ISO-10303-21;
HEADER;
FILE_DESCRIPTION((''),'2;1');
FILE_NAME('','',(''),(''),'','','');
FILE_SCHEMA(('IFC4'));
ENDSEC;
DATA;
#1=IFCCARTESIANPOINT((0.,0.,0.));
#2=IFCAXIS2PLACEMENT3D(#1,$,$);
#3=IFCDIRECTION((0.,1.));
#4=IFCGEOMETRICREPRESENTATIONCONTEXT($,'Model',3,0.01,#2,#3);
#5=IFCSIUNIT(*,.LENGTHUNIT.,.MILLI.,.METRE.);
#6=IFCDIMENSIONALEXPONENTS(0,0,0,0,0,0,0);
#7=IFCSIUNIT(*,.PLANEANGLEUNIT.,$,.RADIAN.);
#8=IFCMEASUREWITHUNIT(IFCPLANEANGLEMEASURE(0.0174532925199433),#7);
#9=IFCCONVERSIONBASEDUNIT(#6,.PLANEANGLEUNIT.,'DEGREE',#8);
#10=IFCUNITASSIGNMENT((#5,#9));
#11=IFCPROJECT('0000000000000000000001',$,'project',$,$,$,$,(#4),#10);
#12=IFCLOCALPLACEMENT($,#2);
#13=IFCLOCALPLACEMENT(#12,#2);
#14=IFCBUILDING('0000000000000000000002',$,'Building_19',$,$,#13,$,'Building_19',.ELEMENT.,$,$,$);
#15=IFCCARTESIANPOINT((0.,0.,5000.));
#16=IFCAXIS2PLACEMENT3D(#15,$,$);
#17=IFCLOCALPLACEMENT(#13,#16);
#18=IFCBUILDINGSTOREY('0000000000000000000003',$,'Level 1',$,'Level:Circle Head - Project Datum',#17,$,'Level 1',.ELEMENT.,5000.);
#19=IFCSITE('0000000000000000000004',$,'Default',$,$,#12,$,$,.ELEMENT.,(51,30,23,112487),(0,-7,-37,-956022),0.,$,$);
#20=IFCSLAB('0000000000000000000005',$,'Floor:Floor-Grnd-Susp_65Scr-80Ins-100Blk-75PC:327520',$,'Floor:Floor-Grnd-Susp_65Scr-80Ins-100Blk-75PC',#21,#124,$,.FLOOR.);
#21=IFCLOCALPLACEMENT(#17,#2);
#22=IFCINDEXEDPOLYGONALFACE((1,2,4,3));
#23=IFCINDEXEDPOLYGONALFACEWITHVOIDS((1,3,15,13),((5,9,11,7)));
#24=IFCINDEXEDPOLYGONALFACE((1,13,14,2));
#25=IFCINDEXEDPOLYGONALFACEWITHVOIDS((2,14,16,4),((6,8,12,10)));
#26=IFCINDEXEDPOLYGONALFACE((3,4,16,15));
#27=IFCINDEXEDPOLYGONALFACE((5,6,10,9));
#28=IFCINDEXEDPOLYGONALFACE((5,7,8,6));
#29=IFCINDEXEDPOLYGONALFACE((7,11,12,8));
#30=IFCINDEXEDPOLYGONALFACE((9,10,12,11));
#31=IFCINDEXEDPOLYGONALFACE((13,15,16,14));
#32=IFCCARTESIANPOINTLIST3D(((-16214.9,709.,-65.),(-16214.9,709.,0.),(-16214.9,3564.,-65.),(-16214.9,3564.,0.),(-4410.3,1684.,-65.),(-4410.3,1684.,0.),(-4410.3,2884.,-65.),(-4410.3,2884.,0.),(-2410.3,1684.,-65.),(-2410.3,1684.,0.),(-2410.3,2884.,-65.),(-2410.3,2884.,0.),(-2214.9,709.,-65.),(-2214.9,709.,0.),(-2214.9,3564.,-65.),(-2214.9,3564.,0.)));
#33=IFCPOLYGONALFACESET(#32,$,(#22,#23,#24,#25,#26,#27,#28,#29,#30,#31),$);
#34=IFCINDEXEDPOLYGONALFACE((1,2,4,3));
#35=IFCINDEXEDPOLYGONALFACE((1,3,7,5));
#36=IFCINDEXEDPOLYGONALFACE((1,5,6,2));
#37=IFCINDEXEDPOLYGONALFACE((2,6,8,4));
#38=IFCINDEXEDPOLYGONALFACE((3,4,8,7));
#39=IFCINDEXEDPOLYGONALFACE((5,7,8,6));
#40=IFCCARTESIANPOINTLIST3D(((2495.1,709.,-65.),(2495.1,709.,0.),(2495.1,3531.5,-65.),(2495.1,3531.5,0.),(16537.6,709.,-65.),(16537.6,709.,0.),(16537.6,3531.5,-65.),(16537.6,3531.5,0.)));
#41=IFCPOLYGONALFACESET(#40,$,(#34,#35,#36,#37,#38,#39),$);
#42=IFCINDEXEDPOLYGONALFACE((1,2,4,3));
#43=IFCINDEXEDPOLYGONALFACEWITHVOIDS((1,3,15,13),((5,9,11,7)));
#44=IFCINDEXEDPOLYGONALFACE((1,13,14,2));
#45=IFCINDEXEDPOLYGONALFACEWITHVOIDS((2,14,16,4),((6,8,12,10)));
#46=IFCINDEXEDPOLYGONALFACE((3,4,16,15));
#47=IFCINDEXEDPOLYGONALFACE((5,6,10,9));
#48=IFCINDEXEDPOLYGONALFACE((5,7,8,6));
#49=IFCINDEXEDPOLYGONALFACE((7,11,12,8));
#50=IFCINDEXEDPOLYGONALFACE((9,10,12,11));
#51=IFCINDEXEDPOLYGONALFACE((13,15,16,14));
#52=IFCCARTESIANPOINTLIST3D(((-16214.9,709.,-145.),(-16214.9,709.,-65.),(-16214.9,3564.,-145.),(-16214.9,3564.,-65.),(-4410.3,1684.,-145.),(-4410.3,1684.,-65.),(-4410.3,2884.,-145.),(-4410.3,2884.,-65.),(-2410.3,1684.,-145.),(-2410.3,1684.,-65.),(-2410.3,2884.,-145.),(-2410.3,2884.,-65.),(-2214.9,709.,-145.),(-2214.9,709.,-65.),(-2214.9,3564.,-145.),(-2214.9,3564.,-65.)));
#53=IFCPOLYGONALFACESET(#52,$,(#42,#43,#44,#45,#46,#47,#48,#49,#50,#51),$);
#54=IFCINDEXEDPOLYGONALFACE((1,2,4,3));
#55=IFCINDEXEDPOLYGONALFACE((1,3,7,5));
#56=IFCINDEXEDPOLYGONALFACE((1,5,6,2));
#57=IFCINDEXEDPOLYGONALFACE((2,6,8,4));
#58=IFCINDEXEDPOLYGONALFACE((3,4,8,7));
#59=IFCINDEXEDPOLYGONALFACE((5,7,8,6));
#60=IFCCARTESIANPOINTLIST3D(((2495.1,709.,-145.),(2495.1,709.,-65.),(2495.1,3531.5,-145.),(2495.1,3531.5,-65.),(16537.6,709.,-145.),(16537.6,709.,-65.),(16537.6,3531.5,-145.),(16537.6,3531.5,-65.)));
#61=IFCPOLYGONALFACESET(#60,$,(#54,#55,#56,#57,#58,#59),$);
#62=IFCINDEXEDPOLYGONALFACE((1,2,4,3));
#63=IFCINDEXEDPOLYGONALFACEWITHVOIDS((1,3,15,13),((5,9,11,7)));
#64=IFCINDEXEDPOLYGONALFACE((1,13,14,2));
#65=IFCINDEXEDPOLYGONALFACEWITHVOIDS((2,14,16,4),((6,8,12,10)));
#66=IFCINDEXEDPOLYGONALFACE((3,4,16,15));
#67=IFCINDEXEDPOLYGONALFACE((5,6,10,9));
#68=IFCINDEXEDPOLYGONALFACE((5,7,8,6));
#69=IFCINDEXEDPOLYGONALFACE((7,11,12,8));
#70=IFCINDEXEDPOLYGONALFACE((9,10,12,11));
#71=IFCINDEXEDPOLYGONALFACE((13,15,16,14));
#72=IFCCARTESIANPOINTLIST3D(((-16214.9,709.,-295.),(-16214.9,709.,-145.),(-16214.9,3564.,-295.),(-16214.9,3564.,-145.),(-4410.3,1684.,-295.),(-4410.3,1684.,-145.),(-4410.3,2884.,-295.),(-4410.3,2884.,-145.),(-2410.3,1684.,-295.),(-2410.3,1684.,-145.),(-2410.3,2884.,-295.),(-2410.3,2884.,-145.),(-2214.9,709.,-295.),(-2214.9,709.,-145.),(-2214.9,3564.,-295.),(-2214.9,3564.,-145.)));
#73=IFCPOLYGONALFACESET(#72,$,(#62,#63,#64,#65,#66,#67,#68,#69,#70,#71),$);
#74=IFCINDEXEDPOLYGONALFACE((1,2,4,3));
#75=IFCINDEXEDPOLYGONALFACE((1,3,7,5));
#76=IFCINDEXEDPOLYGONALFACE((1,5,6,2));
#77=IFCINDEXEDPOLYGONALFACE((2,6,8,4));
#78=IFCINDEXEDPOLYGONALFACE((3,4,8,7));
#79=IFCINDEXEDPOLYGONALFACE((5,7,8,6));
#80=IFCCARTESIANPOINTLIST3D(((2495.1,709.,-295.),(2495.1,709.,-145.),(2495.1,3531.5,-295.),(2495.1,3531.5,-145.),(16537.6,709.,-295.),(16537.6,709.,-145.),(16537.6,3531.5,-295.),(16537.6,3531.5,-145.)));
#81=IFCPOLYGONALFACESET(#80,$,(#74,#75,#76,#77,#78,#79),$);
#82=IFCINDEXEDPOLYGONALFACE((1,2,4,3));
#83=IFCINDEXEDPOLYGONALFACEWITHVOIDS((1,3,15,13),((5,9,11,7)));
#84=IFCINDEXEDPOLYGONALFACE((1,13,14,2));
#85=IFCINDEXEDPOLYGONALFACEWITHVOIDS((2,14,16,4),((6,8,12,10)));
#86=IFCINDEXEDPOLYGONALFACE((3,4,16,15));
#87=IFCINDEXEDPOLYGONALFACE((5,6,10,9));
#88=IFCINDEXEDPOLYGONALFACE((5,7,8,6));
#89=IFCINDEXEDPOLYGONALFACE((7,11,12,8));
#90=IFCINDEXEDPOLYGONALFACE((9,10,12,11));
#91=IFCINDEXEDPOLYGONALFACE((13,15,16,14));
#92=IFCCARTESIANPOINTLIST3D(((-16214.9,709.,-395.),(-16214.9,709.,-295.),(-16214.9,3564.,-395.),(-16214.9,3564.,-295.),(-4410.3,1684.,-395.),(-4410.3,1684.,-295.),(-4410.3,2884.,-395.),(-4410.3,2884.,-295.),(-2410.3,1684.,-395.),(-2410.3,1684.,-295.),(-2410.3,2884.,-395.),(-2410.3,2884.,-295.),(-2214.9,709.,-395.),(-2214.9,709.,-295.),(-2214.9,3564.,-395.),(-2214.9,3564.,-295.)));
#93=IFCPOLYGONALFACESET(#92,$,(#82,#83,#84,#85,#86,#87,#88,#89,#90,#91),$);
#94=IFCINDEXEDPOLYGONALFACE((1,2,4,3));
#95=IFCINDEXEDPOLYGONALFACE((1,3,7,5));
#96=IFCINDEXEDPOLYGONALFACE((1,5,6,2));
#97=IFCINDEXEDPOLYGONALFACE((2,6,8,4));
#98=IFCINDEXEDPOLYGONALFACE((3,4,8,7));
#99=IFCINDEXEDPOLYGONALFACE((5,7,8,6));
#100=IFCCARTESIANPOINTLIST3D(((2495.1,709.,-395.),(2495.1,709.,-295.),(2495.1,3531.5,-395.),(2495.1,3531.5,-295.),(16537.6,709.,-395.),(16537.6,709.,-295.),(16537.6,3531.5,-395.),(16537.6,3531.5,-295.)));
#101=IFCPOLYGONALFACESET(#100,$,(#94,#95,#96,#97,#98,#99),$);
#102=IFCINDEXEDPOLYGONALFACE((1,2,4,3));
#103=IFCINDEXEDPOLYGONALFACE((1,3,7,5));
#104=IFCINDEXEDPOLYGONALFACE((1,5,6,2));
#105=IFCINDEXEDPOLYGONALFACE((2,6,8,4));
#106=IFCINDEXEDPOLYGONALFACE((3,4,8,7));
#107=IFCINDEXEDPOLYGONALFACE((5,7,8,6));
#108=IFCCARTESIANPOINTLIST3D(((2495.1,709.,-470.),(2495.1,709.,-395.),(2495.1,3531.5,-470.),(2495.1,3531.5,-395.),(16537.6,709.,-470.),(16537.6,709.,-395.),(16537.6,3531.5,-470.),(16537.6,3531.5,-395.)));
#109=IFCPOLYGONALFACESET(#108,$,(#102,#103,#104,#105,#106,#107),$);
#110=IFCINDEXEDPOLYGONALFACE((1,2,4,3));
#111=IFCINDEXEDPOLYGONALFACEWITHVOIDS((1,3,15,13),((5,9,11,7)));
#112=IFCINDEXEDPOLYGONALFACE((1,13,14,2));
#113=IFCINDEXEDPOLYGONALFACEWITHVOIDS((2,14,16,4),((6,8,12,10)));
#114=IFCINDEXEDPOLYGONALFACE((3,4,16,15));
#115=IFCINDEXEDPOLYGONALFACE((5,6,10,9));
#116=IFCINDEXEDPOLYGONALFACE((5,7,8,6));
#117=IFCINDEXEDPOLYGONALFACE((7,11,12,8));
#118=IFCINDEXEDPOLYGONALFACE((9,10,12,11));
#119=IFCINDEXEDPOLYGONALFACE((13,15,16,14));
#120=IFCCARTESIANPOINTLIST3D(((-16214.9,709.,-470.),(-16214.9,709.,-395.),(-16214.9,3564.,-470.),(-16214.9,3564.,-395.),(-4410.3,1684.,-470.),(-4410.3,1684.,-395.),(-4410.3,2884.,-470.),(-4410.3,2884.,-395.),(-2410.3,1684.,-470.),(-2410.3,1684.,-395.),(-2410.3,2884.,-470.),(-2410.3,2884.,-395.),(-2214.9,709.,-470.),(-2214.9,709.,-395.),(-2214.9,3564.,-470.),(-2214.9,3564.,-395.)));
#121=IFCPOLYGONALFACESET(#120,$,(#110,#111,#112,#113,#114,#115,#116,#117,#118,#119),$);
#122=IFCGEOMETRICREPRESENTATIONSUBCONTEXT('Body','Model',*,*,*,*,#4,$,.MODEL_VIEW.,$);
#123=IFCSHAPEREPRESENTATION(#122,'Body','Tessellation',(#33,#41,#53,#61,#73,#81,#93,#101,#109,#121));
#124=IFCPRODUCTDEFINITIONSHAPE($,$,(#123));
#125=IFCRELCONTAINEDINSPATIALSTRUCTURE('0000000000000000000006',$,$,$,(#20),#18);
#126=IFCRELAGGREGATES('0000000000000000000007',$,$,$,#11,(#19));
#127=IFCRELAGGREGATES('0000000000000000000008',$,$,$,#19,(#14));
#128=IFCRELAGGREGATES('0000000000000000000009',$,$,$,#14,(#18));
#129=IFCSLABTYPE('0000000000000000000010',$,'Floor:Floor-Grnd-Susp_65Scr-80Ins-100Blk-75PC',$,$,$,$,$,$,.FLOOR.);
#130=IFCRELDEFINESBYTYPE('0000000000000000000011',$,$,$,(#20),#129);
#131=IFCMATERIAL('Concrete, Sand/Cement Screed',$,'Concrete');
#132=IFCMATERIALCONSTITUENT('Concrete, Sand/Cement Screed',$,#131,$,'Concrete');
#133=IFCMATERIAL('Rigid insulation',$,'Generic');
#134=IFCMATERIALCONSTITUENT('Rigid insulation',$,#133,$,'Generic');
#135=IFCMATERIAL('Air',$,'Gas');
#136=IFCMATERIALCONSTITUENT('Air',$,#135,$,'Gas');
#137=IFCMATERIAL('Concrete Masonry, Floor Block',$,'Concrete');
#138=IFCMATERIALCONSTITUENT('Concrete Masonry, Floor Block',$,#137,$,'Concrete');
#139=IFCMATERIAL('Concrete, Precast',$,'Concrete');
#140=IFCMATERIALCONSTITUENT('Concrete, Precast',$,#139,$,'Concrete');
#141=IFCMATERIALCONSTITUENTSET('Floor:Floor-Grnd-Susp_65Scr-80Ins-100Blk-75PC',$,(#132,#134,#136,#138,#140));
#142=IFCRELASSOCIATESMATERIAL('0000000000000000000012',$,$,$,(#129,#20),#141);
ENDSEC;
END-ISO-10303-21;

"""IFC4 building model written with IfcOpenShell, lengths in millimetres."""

from ifc_helpers import new_model, entity, si_unit, converted_unit, direction, frame, origin, place, context, subcontext, project, spatial, indexed_curve, outline, extrude, material, constituent, constituent_set, type_object, element, save


model = new_model("IFC4")

# Units and contexts
model_context = context("Model", 3, precision=0.01, world=origin(), true_north=direction((0.0, 1.0)))
body_context = subcontext(model_context, "Body", "Model", "MODEL_VIEW")
ifc_project = project(units=[si_unit("LENGTHUNIT", "METRE", prefix="MILLI"), converted_unit("PLANEANGLEUNIT", "DEGREE", entity("IfcPlaneAngleMeasure", 0.0174532925199433), si_unit("PLANEANGLEUNIT", "RADIAN"), dimensions=[0, 0, 0, 0, 0, 0, 0])], contexts=[model_context])

# Site, building, storey
site_placement = place(None, origin())
site = spatial("IfcSite", under=ifc_project, at=site_placement, Name="Default", CompositionType="ELEMENT", RefLatitude=(51, 30, 23, 112487), RefLongitude=(0, -7, -37, -956022), RefElevation=0.0)
building_placement = place(site_placement, origin())
building = spatial("IfcBuilding", under=site, at=building_placement, Name="Building_19", LongName="Building_19", CompositionType="ELEMENT")
storey_placement = place(building_placement, frame((0.0, 0.0, 5000.0)))
storey = spatial("IfcBuildingStorey", under=building, at=storey_placement, Name="Level 1", ObjectType="Level:Circle Head - Project Datum", LongName="Level 1", CompositionType="ELEMENT", Elevation=5000.0)

# Slab, opening
ifc_material_1 = material(Name="Concrete, Sand/Cement Screed", Category="Concrete")
ifc_constituent_1 = constituent(ifc_material_1, Name="Concrete, Sand/Cement Screed", Category="Concrete")
ifc_material_2 = material(Name="Rigid insulation", Category="Generic")
ifc_constituent_2 = constituent(ifc_material_2, Name="Rigid insulation", Category="Generic")
ifc_material_3 = material(Name="Air", Category="Gas")
ifc_constituent_3 = constituent(ifc_material_3, Name="Air", Category="Gas")
ifc_material_4 = material(Name="Concrete Masonry, Floor Block", Category="Concrete")
ifc_constituent_4 = constituent(ifc_material_4, Name="Concrete Masonry, Floor Block", Category="Concrete")
ifc_material_5 = material(Name="Concrete, Precast", Category="Concrete")
ifc_constituent_5 = constituent(ifc_material_5, Name="Concrete, Precast", Category="Concrete")
ifc_constituent_set_1 = constituent_set(constituents=[ifc_constituent_1, ifc_constituent_2, ifc_constituent_3, ifc_constituent_4, ifc_constituent_5], Name="Floor:Floor-Grnd-Susp_65Scr-80Ins-100Blk-75PC")
slab_type = type_object("IfcSlabType", Name="Floor:Floor-Grnd-Susp_65Scr-80Ins-100Blk-75PC", PredefinedType="FLOOR", material=ifc_constituent_set_1)
slab_1_placement = place(storey_placement, origin())
slab_1 = element("IfcSlab", 1, at=slab_1_placement, inside=storey, type_object=slab_type, material=ifc_constituent_set_1, Name="Floor:Floor-Grnd-Susp_65Scr-80Ins-100Blk-75PC:327520", ObjectType="Floor:Floor-Grnd-Susp_65Scr-80Ins-100Blk-75PC", PredefinedType="FLOOR", context=body_context, shape_type="SweptSolid", body=[
    extrude(outline(indexed_curve([(-7000.0, -1427.5), (7000.0, -1427.5), (7000.0, 1427.5), (-7000.0, 1427.5), (-7000.0, -1427.5)], self_intersect=False), holes=[indexed_curve([(-4804.6, -747.5), (-6804.6, -747.5), (-6804.6, 452.5), (-4804.6, 452.5), (-4804.6, -747.5)], self_intersect=False)]), frame((-9214.9, 2136.5, -65.0), z_axis=(0.0, 0.0, 1.0), x_axis=(-1.0, 0.0, 0.0)), (0.0, 0.0, 1.0), 65.0),
    extrude(outline(indexed_curve([(-7021.2, -1411.3), (7021.2, -1411.3), (7021.2, 1411.3), (-7021.2, 1411.3), (-7021.2, -1411.3)], self_intersect=False)), frame((9516.3, 2120.2, -65.0), z_axis=(0.0, 0.0, 1.0), x_axis=(-1.0, 0.0, 0.0)), (0.0, 0.0, 1.0), 65.0),
    extrude(outline(indexed_curve([(-7000.0, -1427.5), (7000.0, -1427.5), (7000.0, 1427.5), (-7000.0, 1427.5), (-7000.0, -1427.5)], self_intersect=False), holes=[indexed_curve([(-4804.6, -747.5), (-6804.6, -747.5), (-6804.6, 452.5), (-4804.6, 452.5), (-4804.6, -747.5)], self_intersect=False)]), frame((-9214.9, 2136.5, -145.0), z_axis=(0.0, 0.0, 1.0), x_axis=(-1.0, 0.0, 0.0)), (0.0, 0.0, 1.0), 80.0),
    extrude(outline(indexed_curve([(-7021.2, -1411.3), (7021.2, -1411.3), (7021.2, 1411.3), (-7021.2, 1411.3), (-7021.2, -1411.3)], self_intersect=False)), frame((9516.3, 2120.2, -145.0), z_axis=(0.0, 0.0, 1.0), x_axis=(-1.0, 0.0, 0.0)), (0.0, 0.0, 1.0), 80.0),
    extrude(outline(indexed_curve([(-7000.0, -1427.5), (7000.0, -1427.5), (7000.0, 1427.5), (-7000.0, 1427.5), (-7000.0, -1427.5)], self_intersect=False), holes=[indexed_curve([(-4804.6, -747.5), (-6804.6, -747.5), (-6804.6, 452.5), (-4804.6, 452.5), (-4804.6, -747.5)], self_intersect=False)]), frame((-9214.9, 2136.5, -295.0), z_axis=(0.0, 0.0, 1.0), x_axis=(-1.0, 0.0, 0.0)), (0.0, 0.0, 1.0), 150.0),
    extrude(outline(indexed_curve([(-7021.2, -1411.3), (7021.2, -1411.3), (7021.2, 1411.3), (-7021.2, 1411.3), (-7021.2, -1411.3)], self_intersect=False)), frame((9516.3, 2120.2, -295.0), z_axis=(0.0, 0.0, 1.0), x_axis=(-1.0, 0.0, 0.0)), (0.0, 0.0, 1.0), 150.0),
    extrude(outline(indexed_curve([(-7000.0, -1427.5), (7000.0, -1427.5), (7000.0, 1427.5), (-7000.0, 1427.5), (-7000.0, -1427.5)], self_intersect=False), holes=[indexed_curve([(-4804.6, -747.5), (-6804.6, -747.5), (-6804.6, 452.5), (-4804.6, 452.5), (-4804.6, -747.5)], self_intersect=False)]), frame((-9214.9, 2136.5, -395.0), z_axis=(0.0, 0.0, 1.0), x_axis=(-1.0, 0.0, 0.0)), (0.0, 0.0, 1.0), 100.0),
    extrude(outline(indexed_curve([(-7021.2, -1411.3), (7021.2, -1411.3), (7021.2, 1411.3), (-7021.2, 1411.3), (-7021.2, -1411.3)], self_intersect=False)), frame((9516.3, 2120.2, -395.0), z_axis=(0.0, 0.0, 1.0), x_axis=(-1.0, 0.0, 0.0)), (0.0, 0.0, 1.0), 100.0),
    extrude(outline(indexed_curve([(-7021.2, -1411.3), (7021.2, -1411.3), (7021.2, 1411.3), (-7021.2, 1411.3), (-7021.2, -1411.3)], self_intersect=False)), frame((9516.3, 2120.2, -470.0), z_axis=(0.0, 0.0, 1.0), x_axis=(-1.0, 0.0, 0.0)), (0.0, 0.0, 1.0), 75.0),
    extrude(outline(indexed_curve([(-7000.0, -1427.5), (7000.0, -1427.5), (7000.0, 1427.5), (-7000.0, 1427.5), (-7000.0, -1427.5)], self_intersect=False), holes=[indexed_curve([(-4804.6, -747.5), (-6804.6, -747.5), (-6804.6, 452.5), (-4804.6, 452.5), (-4804.6, -747.5)], self_intersect=False)]), frame((-9214.9, 2136.5, -470.0), z_axis=(0.0, 0.0, 1.0), x_axis=(-1.0, 0.0, 0.0)), (0.0, 0.0, 1.0), 75.0),
])
opening_1_placement = place(slab_1_placement, origin())
element("IfcOpeningElement", 2, at=opening_1_placement, cuts=slab_1, PredefinedType="OPENING", context=body_context, shape_type="SweptSolid", body=[
    extrude(outline(indexed_curve([(-600.0, -1000.0), (600.0, -1000.0), (600.0, 1000.0), (-600.0, 1000.0), (-600.0, -1000.0)], self_intersect=False)), frame((-3410.3, 2284.0, -470.0), z_axis=(0.0, 0.0, 1.0), x_axis=(0.0, -1.0, 0.0)), (0.0, 0.0, 1.0), 470.0),
])

save(model, "model.ifc")
